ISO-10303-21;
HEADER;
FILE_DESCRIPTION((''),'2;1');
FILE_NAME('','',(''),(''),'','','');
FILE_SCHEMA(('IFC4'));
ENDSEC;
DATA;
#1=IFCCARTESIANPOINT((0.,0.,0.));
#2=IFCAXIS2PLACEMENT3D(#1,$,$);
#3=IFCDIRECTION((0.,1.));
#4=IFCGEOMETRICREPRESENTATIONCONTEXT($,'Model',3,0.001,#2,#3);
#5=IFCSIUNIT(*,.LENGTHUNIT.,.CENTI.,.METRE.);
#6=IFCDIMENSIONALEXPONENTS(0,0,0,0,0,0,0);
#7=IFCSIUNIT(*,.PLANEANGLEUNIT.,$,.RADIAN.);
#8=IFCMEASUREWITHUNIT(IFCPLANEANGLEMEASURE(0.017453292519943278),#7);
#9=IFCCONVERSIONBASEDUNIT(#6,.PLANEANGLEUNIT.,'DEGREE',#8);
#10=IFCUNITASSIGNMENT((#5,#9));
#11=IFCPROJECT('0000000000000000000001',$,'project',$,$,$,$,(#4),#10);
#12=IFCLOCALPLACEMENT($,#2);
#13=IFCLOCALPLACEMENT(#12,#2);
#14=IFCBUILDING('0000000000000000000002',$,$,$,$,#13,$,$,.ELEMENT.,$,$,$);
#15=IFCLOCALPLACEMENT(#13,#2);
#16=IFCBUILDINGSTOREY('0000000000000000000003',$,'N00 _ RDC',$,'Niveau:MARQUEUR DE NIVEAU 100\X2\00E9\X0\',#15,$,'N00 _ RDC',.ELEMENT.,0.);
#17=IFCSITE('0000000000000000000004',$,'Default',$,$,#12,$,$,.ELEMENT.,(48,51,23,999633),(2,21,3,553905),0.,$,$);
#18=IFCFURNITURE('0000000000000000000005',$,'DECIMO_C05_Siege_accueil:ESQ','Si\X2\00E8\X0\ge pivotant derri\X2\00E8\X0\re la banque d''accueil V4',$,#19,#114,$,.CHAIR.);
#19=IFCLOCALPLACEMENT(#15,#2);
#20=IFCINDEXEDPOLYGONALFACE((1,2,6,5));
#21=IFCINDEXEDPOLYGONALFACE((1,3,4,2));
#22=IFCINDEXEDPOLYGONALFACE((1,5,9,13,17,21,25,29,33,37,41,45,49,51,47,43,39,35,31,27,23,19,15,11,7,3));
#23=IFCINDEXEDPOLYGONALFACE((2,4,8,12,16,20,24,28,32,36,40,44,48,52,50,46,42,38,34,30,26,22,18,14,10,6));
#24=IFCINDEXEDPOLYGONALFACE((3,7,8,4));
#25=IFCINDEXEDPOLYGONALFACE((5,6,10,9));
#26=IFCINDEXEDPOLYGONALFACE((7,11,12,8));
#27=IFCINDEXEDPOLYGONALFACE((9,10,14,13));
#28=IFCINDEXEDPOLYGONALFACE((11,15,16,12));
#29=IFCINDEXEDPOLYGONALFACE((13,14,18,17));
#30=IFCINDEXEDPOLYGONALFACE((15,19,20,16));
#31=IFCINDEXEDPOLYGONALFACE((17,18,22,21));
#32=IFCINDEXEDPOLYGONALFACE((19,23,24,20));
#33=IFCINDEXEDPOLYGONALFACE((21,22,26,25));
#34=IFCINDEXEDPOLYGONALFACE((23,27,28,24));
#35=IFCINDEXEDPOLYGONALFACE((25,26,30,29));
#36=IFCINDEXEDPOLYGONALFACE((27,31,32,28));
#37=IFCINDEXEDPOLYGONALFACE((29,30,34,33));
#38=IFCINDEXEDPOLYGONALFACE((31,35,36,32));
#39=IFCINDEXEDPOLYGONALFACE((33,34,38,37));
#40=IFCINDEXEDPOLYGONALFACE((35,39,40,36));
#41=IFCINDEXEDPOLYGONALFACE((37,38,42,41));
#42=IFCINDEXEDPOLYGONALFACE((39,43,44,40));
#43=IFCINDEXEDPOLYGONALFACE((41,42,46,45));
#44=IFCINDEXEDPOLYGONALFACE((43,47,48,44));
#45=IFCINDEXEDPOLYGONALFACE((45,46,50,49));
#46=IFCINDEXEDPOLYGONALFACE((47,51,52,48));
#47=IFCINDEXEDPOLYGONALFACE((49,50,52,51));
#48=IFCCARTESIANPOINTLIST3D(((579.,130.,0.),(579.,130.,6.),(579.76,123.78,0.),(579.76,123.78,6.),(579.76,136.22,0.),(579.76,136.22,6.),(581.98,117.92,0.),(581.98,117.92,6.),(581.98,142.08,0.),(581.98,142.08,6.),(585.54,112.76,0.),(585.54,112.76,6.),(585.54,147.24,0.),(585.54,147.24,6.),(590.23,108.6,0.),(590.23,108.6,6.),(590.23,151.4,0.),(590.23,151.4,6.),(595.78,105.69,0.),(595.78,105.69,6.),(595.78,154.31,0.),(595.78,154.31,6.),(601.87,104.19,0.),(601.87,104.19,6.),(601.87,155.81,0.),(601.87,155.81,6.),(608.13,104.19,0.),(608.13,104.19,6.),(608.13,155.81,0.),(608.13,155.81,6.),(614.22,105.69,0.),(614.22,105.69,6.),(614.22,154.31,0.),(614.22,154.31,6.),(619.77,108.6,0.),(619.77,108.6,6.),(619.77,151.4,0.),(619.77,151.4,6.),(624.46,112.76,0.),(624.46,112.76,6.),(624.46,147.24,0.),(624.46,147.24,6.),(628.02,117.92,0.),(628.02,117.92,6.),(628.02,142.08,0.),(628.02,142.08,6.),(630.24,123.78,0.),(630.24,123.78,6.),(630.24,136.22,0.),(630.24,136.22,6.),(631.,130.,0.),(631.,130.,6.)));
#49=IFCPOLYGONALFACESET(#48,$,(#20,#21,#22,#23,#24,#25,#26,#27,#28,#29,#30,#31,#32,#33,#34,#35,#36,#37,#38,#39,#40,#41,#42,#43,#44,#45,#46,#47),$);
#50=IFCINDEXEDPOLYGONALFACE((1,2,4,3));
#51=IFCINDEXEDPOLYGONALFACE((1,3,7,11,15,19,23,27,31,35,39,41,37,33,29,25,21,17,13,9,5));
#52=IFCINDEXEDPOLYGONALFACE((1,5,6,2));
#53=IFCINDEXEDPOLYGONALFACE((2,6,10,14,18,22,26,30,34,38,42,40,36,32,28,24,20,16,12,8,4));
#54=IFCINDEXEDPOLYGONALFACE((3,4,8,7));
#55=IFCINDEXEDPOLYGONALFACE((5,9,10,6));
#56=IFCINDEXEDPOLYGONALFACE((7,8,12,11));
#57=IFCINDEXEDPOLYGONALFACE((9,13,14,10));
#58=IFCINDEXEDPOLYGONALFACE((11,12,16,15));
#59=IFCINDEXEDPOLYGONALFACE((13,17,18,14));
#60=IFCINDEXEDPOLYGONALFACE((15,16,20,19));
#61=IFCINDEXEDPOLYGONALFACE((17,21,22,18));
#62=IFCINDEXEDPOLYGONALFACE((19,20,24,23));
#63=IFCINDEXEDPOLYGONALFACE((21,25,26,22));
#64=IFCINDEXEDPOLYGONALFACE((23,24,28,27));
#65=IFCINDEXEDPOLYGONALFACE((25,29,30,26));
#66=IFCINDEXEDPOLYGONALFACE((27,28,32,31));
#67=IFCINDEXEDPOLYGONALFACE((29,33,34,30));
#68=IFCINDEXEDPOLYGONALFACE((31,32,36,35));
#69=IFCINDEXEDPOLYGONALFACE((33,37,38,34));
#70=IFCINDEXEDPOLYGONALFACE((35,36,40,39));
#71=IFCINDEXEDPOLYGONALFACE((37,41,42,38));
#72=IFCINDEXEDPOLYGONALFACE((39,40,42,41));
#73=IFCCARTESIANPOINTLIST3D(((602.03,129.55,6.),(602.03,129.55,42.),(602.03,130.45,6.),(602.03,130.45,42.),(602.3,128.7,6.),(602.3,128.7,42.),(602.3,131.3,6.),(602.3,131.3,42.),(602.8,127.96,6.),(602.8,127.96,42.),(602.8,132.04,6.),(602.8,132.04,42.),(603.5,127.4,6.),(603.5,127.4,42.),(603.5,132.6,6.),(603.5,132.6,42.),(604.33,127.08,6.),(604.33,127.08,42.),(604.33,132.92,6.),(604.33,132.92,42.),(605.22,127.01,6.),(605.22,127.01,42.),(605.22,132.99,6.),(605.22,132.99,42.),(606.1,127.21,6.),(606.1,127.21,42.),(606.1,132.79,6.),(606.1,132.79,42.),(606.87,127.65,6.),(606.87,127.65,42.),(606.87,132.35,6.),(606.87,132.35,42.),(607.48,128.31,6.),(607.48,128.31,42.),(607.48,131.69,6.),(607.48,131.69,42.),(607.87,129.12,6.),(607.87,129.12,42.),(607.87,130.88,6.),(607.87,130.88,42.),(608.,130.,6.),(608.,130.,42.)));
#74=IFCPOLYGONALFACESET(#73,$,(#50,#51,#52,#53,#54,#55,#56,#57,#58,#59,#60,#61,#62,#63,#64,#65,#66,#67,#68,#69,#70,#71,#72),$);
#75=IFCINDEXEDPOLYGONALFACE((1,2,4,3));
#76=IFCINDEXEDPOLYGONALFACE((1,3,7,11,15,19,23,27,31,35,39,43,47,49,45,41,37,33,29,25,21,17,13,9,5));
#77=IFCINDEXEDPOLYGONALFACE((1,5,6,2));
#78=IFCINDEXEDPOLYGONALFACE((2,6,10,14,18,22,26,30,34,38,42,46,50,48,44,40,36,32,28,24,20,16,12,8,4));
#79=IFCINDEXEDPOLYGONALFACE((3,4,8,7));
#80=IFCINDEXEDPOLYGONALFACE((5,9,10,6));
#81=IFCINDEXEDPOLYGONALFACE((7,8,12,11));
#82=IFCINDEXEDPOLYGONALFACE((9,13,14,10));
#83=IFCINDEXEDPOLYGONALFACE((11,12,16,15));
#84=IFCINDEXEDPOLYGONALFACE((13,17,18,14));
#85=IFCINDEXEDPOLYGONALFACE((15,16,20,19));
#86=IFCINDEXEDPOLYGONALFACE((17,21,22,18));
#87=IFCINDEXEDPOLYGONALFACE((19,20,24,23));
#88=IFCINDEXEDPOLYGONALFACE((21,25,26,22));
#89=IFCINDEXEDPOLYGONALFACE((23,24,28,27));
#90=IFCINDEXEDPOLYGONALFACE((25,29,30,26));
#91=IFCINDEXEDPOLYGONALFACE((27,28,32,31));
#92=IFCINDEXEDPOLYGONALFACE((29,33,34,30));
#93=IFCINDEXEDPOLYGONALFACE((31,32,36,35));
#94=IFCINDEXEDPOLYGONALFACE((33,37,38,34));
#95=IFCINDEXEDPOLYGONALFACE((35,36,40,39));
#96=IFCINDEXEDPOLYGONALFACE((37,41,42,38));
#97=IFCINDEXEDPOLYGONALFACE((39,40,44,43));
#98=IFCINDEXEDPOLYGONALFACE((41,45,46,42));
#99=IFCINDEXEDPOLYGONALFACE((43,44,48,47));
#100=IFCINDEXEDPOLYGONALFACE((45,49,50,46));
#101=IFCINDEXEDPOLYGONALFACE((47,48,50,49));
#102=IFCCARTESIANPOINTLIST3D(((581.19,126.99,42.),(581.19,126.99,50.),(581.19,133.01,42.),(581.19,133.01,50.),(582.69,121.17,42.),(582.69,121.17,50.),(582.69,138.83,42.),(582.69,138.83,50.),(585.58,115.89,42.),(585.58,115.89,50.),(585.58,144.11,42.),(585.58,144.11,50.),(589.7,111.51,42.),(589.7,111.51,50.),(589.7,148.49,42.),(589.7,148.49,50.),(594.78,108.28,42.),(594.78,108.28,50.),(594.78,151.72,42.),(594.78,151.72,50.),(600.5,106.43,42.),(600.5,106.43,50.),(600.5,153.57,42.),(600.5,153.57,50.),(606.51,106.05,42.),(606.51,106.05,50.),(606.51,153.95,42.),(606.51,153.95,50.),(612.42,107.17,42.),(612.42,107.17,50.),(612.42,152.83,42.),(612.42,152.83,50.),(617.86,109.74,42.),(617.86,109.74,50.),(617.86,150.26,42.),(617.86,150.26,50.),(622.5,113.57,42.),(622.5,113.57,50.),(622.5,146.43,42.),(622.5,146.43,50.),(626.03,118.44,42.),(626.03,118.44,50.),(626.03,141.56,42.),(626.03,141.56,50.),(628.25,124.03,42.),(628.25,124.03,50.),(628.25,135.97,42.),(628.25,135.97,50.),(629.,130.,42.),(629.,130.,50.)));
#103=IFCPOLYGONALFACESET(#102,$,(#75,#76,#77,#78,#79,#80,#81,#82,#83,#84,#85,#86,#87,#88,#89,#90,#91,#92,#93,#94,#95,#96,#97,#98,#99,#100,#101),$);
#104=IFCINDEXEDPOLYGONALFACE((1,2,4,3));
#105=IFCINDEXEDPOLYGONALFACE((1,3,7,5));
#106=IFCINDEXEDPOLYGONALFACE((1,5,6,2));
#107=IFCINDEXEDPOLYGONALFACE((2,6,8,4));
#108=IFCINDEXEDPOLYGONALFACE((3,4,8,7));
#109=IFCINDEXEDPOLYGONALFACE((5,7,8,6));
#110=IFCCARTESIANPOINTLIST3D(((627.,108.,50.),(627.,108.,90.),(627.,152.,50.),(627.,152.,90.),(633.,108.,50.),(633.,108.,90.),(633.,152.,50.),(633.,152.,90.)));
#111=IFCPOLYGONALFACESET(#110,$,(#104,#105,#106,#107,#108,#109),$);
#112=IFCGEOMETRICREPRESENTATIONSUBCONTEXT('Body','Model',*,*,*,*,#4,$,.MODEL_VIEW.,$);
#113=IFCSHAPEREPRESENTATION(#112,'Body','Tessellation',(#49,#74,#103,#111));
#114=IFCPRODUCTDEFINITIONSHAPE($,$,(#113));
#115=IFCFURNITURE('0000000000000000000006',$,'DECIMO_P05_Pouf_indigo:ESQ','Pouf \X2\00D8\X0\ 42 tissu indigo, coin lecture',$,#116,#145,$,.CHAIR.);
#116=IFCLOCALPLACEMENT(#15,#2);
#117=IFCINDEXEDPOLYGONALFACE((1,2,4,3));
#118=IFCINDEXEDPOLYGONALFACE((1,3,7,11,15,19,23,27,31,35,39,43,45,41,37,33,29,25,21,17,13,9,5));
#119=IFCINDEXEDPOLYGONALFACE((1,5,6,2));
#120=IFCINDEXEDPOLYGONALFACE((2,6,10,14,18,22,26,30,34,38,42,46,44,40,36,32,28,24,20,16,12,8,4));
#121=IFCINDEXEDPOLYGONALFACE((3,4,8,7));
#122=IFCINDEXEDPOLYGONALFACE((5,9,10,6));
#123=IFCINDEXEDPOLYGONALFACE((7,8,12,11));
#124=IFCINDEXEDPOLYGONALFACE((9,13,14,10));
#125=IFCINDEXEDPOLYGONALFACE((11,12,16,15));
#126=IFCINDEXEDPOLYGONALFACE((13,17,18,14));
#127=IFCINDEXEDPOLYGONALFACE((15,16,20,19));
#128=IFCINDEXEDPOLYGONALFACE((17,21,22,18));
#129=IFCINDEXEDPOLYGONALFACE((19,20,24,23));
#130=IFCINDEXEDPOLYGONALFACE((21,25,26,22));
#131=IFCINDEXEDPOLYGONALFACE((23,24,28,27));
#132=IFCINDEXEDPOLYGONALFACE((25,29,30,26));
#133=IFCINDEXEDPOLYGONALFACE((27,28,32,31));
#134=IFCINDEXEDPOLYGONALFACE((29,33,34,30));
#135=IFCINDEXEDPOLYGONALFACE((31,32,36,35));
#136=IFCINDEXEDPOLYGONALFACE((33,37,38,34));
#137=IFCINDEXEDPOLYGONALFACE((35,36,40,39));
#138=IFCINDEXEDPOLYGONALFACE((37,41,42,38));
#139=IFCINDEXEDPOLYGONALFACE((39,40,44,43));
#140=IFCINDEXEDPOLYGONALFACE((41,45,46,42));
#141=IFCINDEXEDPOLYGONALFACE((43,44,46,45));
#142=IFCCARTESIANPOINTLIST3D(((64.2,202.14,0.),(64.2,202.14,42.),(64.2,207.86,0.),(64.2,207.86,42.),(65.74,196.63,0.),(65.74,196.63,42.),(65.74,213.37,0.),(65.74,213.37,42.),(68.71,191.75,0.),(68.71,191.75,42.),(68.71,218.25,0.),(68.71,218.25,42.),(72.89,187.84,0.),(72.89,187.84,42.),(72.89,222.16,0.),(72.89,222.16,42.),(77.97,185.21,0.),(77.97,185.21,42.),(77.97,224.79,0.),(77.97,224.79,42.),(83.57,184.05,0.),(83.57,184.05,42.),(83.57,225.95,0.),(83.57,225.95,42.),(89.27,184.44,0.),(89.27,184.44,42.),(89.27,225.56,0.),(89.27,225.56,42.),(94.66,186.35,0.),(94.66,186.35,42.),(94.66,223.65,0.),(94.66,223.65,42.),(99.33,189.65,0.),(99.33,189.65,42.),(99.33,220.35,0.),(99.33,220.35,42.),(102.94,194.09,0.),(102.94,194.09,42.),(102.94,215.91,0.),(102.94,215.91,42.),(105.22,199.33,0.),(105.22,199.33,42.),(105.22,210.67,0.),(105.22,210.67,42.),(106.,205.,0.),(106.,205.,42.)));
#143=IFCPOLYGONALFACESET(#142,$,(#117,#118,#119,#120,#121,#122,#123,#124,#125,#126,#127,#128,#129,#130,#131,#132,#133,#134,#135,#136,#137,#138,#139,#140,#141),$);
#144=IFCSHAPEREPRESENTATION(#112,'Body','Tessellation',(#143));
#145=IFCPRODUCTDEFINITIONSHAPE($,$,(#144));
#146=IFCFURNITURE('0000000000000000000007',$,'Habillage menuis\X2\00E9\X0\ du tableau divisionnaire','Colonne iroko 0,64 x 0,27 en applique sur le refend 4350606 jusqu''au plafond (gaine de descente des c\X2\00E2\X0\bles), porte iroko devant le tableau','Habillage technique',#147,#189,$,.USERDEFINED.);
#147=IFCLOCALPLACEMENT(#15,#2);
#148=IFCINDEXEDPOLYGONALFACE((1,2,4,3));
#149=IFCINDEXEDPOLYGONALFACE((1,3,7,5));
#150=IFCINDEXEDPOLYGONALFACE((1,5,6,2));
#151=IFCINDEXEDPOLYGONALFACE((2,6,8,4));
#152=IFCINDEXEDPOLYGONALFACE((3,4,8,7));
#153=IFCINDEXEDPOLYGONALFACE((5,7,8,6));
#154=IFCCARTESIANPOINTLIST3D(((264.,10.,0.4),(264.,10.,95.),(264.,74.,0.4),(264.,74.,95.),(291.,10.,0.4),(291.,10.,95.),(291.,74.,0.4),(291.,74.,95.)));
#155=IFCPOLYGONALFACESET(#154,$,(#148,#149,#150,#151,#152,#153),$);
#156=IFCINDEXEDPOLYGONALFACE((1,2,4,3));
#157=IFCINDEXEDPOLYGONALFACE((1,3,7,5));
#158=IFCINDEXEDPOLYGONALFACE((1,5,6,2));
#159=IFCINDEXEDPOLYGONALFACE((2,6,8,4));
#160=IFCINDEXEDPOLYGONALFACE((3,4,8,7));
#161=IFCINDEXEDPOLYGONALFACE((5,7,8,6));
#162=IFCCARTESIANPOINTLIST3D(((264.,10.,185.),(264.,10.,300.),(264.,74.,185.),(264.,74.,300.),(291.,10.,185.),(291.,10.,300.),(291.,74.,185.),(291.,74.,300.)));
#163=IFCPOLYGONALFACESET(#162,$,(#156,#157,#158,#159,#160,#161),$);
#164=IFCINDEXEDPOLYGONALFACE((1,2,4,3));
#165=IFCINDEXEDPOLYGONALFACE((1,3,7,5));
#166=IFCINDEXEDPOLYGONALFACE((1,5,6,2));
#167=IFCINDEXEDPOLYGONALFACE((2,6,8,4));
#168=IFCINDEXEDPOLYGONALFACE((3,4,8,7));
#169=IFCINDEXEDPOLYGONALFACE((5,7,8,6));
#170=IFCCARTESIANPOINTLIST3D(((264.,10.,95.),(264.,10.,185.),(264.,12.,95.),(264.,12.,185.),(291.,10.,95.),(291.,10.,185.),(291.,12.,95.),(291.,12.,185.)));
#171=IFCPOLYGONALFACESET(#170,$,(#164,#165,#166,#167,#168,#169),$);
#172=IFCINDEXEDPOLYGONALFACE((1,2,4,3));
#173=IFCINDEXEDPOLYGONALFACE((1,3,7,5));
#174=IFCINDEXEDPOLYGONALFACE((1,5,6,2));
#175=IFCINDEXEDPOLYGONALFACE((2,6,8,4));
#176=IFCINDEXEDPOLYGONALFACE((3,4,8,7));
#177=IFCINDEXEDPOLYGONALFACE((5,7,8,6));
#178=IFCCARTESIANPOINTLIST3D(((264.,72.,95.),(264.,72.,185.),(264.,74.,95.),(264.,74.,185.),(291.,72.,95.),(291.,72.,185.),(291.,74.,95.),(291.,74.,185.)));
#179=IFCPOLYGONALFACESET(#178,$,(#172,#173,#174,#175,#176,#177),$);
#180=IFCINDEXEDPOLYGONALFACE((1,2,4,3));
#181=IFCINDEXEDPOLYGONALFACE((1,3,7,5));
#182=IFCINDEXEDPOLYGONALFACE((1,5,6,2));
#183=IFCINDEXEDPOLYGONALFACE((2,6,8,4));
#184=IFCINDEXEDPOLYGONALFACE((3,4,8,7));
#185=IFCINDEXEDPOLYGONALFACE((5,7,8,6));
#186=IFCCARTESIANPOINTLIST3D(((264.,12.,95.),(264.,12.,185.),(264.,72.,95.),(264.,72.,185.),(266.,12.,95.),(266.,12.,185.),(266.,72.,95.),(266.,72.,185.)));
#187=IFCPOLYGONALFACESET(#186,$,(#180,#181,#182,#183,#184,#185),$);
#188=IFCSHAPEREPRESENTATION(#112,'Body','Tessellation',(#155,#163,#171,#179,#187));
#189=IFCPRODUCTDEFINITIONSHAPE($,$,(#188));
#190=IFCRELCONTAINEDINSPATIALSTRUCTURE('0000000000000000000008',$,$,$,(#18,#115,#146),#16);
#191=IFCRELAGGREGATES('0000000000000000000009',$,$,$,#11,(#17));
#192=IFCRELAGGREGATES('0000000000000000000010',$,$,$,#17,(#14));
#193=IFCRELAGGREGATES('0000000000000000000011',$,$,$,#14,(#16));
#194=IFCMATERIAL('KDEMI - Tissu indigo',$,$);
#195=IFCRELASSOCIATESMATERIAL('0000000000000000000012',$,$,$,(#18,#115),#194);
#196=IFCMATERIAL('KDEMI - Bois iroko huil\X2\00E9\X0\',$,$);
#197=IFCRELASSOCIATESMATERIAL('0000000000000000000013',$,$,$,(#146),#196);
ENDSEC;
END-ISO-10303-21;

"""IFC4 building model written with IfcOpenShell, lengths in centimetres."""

from ifc_helpers import new_model, entity, si_unit, converted_unit, direction, frame, frame_2d, origin, origin_with_axes, place, context, subcontext, project, spatial, rectangle, circle, extrude, material, element, save


model = new_model("IFC4")

# Units and contexts
model_context = context("Model", 3, precision=0.001, world=origin(), true_north=direction((0.0, 1.0)))
body_context = subcontext(model_context, "Body", "Model", "MODEL_VIEW")
ifc_project = project(units=[si_unit("LENGTHUNIT", "METRE", prefix="CENTI"), converted_unit("PLANEANGLEUNIT", "DEGREE", entity("IfcPlaneAngleMeasure", 0.017453292519943278), si_unit("PLANEANGLEUNIT", "RADIAN"), dimensions=[0, 0, 0, 0, 0, 0, 0])], contexts=[model_context])

# Site, building, storey
site_placement = place(None, origin())
site = spatial("IfcSite", under=ifc_project, at=site_placement, Name="Default", CompositionType="ELEMENT", RefLatitude=(48, 51, 23, 999633), RefLongitude=(2, 21, 3, 553905), RefElevation=0.0)
building_placement = place(site_placement, origin())
building = spatial("IfcBuilding", under=site, at=building_placement, CompositionType="ELEMENT")
storey_placement = place(building_placement, origin())
storey = spatial("IfcBuildingStorey", under=building, at=storey_placement, Name="N00 _ RDC", ObjectType="Niveau:MARQUEUR DE NIVEAU 100é", LongName="N00 _ RDC", CompositionType="ELEMENT", Elevation=0.0)

# Shared definitions
ifc_material_1 = material(Name="KDEMI - Bois iroko huilé")

# Furniture
ifc_material_2 = material(Name="KDEMI - Tissu indigo")
furniture_1_placement = place(storey_placement, origin_with_axes())
element("IfcFurniture", 1, at=furniture_1_placement, inside=storey, material=ifc_material_2, Name="DECIMO_C05_Siege_accueil:ESQ", Description="Siège pivotant derrière la banque d'accueil V4", PredefinedType="CHAIR", context=body_context, shape_type="SweptSolid", body=[
    extrude(circle(Radius=26.0, at=frame_2d((605.0, 130.0))), origin(), (0.0, 0.0, 1.0), 6.0),
    extrude(circle(Radius=3.0, at=frame_2d((605.0, 130.0))), frame((0.0, 0.0, 6.0)), (0.0, 0.0, 1.0), 36.0),
    extrude(circle(Radius=24.0, at=frame_2d((605.0, 130.0))), frame((0.0, 0.0, 42.0)), (0.0, 0.0, 1.0), 8.0),
    extrude(rectangle(XDim=6.0, YDim=44.0, at=frame_2d((630.0, 130.0))), frame((0.0, 0.0, 50.0)), (0.0, 0.0, 1.0), 40.0),
])
furniture_2_placement = place(storey_placement, origin_with_axes())
element("IfcFurniture", 2, at=furniture_2_placement, inside=storey, material=ifc_material_2, Name="DECIMO_P05_Pouf_indigo:ESQ", Description="Pouf Ø 42 tissu indigo, coin lecture", PredefinedType="CHAIR", context=body_context, shape_type="SweptSolid", body=[
    extrude(circle(Radius=21.0, at=frame_2d((85.0, 205.0))), origin(), (0.0, 0.0, 1.0), 42.0),
])
furniture_3_placement = place(storey_placement, origin_with_axes())
element("IfcFurniture", 3, at=furniture_3_placement, inside=storey, material=ifc_material_1, Name="Habillage menuisé du tableau divisionnaire", Description="Colonne iroko 0,64 x 0,27 en applique sur le refend 4350606 jusqu'au plafond (gaine de descente des câbles), porte iroko devant le tableau", ObjectType="Habillage technique", PredefinedType="USERDEFINED", context=body_context, shape_type="SweptSolid", body=[
    extrude(rectangle(XDim=27.0, YDim=64.0, at=frame_2d((277.5, 42.0))), frame((0.0, 0.0, 0.4)), (0.0, 0.0, 1.0), 94.6),
    extrude(rectangle(XDim=27.0, YDim=64.0, at=frame_2d((277.5, 42.0))), frame((0.0, 0.0, 185.0)), (0.0, 0.0, 1.0), 115.0),
    extrude(rectangle(XDim=27.0, YDim=2.0, at=frame_2d((277.5, 11.0))), frame((0.0, 0.0, 95.0)), (0.0, 0.0, 1.0), 90.0),
    extrude(rectangle(XDim=27.0, YDim=2.0, at=frame_2d((277.5, 73.0))), frame((0.0, 0.0, 95.0)), (0.0, 0.0, 1.0), 90.0),
    extrude(rectangle(XDim=2.0, YDim=60.0, at=frame_2d((265.0, 42.0))), frame((0.0, 0.0, 95.0)), (0.0, 0.0, 1.0), 90.0),
])

save(model, "model.ifc")
